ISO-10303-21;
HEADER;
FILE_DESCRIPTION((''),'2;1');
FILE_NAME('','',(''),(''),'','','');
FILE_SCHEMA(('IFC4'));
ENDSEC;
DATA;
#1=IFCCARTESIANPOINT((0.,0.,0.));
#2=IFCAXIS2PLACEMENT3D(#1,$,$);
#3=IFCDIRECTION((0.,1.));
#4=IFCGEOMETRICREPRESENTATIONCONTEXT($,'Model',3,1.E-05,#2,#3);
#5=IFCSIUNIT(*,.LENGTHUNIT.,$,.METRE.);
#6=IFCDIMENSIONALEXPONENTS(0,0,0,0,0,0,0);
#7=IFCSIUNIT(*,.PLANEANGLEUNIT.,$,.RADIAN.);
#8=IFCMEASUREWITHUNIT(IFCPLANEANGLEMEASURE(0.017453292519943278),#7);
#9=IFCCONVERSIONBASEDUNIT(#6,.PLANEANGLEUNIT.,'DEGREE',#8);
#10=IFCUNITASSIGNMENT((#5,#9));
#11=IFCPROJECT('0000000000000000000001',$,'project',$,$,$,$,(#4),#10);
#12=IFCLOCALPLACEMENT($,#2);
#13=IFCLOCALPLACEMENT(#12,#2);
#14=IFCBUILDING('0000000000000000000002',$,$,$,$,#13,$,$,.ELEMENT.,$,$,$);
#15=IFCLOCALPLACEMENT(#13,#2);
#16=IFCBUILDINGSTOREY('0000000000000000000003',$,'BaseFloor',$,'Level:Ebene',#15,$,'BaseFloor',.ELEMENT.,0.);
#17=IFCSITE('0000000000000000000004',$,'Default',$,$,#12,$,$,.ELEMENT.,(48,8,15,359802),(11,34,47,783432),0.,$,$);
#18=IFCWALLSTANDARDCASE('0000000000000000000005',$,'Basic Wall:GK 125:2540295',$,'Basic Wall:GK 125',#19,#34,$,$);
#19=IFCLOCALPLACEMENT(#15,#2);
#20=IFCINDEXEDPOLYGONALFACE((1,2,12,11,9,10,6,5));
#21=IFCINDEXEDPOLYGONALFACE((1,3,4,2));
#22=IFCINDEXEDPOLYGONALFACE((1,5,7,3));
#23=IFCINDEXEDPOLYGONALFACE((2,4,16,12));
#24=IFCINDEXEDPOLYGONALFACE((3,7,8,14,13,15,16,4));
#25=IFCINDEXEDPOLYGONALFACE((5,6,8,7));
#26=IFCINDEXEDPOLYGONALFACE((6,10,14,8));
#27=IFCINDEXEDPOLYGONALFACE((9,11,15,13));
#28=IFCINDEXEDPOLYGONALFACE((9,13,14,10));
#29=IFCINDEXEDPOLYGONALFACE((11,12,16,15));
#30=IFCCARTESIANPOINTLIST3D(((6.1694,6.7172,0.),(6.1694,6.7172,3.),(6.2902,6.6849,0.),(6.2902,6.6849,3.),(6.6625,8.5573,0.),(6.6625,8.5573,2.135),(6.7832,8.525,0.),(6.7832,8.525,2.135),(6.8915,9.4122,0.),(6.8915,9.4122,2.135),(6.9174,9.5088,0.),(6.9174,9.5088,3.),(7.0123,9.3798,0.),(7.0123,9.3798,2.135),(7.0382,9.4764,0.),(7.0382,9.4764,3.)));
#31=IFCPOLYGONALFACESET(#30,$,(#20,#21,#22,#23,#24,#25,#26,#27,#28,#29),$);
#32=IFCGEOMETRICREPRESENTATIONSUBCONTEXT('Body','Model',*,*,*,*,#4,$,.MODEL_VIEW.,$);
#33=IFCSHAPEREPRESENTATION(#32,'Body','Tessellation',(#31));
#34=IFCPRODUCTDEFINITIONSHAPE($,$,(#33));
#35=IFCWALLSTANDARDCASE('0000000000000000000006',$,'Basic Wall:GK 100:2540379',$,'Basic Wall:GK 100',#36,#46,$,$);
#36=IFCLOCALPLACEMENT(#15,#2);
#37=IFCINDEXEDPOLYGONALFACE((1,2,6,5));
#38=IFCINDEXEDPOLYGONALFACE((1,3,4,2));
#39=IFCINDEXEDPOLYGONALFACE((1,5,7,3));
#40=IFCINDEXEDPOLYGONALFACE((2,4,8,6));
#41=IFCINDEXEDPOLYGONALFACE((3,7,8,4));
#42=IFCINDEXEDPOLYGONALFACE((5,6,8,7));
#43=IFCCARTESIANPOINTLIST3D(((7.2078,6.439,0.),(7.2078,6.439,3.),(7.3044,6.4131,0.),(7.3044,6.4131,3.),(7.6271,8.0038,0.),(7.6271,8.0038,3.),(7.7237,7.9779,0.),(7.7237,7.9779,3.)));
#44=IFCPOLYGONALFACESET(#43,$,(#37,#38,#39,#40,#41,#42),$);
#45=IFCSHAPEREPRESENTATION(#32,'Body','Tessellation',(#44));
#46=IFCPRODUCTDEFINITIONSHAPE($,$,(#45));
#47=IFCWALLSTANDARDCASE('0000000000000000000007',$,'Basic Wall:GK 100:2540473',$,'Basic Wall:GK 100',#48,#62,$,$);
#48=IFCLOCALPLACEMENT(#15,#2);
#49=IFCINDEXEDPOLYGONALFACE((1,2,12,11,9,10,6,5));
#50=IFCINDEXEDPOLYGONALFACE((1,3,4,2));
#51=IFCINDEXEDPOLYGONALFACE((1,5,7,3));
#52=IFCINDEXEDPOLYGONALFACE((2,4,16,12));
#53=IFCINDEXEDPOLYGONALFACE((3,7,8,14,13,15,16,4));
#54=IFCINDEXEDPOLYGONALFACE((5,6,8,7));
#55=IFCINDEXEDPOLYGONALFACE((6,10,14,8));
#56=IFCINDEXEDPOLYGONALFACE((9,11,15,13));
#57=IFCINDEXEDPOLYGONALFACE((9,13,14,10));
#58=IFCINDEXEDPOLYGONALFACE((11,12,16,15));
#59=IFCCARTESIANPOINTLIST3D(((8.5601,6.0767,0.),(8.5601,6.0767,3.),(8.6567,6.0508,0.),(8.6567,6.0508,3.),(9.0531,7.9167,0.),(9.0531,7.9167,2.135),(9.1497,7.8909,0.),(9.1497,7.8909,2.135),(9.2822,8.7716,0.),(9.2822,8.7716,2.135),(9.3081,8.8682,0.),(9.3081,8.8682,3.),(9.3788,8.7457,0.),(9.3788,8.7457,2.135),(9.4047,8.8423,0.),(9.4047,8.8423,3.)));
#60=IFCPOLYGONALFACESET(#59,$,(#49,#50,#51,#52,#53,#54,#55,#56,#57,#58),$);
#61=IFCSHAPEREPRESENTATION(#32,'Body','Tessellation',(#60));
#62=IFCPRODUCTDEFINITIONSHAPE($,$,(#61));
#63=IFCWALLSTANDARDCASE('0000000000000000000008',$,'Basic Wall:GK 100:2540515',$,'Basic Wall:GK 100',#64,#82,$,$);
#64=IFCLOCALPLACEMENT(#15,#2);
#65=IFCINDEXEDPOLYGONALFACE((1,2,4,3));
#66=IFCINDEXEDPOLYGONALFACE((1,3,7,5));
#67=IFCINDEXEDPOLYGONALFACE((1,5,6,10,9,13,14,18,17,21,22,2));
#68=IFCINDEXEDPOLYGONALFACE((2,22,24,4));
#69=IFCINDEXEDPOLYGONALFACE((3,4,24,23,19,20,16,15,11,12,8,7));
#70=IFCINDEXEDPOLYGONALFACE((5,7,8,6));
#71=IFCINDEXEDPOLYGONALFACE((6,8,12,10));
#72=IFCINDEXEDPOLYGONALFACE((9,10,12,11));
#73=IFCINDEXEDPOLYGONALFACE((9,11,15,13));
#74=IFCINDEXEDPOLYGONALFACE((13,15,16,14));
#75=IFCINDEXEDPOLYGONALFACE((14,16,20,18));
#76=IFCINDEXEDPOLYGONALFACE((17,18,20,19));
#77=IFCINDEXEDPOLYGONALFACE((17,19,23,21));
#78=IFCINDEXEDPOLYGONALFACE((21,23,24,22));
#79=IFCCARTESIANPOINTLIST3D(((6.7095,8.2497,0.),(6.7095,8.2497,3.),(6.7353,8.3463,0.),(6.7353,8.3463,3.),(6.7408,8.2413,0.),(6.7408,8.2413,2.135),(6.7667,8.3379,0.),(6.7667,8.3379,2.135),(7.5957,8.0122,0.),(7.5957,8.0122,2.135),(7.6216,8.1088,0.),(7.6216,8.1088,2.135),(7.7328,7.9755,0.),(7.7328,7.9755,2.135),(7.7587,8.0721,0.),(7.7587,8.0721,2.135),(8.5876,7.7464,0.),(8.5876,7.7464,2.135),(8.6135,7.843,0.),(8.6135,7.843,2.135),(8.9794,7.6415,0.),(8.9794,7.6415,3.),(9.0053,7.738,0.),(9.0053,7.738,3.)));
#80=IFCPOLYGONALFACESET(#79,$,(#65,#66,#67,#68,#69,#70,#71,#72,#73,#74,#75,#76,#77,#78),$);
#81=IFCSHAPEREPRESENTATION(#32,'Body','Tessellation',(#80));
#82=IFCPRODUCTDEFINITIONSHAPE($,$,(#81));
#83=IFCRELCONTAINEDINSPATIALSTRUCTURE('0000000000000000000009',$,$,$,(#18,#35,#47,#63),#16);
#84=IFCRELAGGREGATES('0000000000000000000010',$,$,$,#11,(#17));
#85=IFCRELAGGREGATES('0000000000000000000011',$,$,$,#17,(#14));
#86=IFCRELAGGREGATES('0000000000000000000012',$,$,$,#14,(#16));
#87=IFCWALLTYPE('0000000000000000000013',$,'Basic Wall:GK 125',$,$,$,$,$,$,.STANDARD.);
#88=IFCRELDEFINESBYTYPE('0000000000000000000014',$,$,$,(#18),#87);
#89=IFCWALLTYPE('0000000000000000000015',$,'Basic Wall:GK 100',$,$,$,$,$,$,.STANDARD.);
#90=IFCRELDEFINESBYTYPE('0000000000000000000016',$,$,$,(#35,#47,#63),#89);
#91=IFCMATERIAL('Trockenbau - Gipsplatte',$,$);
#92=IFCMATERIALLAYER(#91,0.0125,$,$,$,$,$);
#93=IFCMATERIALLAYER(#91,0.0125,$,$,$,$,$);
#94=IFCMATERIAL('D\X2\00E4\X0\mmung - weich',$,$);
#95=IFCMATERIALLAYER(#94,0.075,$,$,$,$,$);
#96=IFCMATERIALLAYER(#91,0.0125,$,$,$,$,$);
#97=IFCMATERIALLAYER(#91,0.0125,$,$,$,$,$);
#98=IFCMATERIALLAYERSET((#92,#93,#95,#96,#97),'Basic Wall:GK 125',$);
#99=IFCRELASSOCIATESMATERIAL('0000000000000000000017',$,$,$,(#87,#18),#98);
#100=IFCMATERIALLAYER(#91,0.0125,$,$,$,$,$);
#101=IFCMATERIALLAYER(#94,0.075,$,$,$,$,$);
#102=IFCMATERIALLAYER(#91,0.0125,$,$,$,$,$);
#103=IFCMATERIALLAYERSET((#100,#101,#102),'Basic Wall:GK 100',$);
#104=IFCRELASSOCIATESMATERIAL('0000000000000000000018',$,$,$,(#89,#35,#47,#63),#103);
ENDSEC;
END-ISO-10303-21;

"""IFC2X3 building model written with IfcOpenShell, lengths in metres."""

from ifc_helpers import new_model, entity, si_unit, converted_unit, direction, frame, frame_2d, origin, place, context, subcontext, project, spatial, rectangle, extrude, material, layer, layer_set, layer_usage, type_object, element, save


model = new_model("IFC2X3")

# Units and contexts
model_context = context("Model", 3, precision=1e-05, world=origin(), true_north=direction((0.0, 1.0)))
body_context = subcontext(model_context, "Body", "Model", "MODEL_VIEW")
ifc_project = project(units=[si_unit("LENGTHUNIT", "METRE"), converted_unit("PLANEANGLEUNIT", "DEGREE", entity("IfcPlaneAngleMeasure", 0.017453292519943278), si_unit("PLANEANGLEUNIT", "RADIAN"), dimensions=[0, 0, 0, 0, 0, 0, 0])], contexts=[model_context])

# Site, building, storey
site_placement = place(None, origin())
site = spatial("IfcSite", under=ifc_project, at=site_placement, Name="Default", CompositionType="ELEMENT", RefLatitude=(48, 8, 15, 359802), RefLongitude=(11, 34, 47, 783432), RefElevation=0.0)
building_placement = place(site_placement, origin())
building = spatial("IfcBuilding", under=site, at=building_placement, CompositionType="ELEMENT")
storey_placement = place(building_placement, origin())
storey = spatial("IfcBuildingStorey", under=building, at=storey_placement, Name="BaseFloor", ObjectType="Level:Ebene", LongName="BaseFloor", CompositionType="ELEMENT", Elevation=0.0)

# Wall, opening
ifc_material_1 = material(Name="Trockenbau - Gipsplatte")
ifc_layer_1 = layer(ifc_material_1, 0.0125)
ifc_layer_2 = layer(ifc_material_1, 0.0125)
ifc_material_2 = material(Name="Dämmung - weich")
ifc_layer_3 = layer(ifc_material_2, 0.075)
ifc_layer_4 = layer(ifc_material_1, 0.0125)
ifc_layer_5 = layer(ifc_material_1, 0.0125)
ifc_layer_set_1 = layer_set([ifc_layer_1, ifc_layer_2, ifc_layer_3, ifc_layer_4, ifc_layer_5], Name="Basic Wall:GK 125")
ifc_layer_usage_1 = layer_usage(ifc_layer_set_1, "AXIS2", "NEGATIVE", 0.0625)
wall_type_1 = type_object("IfcWallType", Name="Basic Wall:GK 125", PredefinedType="STANDARD", material=ifc_layer_set_1)
wall_1_placement = place(storey_placement, frame((6.2298, 6.7011, 0.0), z_axis=(0.0, 0.0, 1.0), x_axis=(0.258819, 0.965926, 0.0)))
wall_1 = element("IfcWallStandardCase", 1, at=wall_1_placement, inside=storey, type_object=wall_type_1, material=ifc_layer_usage_1, Name="Basic Wall:GK 125:2540295", ObjectType="Basic Wall:GK 125", context=body_context, shape_type="SweptSolid", body=[
    extrude(rectangle(XDim=2.89, YDim=0.125, at=frame_2d((1.445, 0.0), x_axis=(-1.0, 0.0))), origin(), (0.0, 0.0, 1.0), 3.0),
])
opening_1_placement = place(wall_1_placement, frame((1.905, -0.0625, -0.18)))
element("IfcOpeningElement", 2, at=opening_1_placement, cuts=wall_1, ObjectType="Opening", context=body_context, shape_type="SweptSolid", body=[
    extrude(rectangle(XDim=2.315, YDim=0.885, at=frame_2d((1.1575, 0.4425), x_axis=(-1.0, 0.0))), frame((0.0, 0.0, 0.0), z_axis=(0.0, 1.0, 0.0), x_axis=(0.0, 0.0, 1.0)), (0.0, 0.0, 1.0), 0.125),
])

# Wall
ifc_layer_6 = layer(ifc_material_1, 0.0125)
ifc_layer_7 = layer(ifc_material_2, 0.075)
ifc_layer_8 = layer(ifc_material_1, 0.0125)
ifc_layer_set_2 = layer_set([ifc_layer_6, ifc_layer_7, ifc_layer_8], Name="Basic Wall:GK 100")
ifc_layer_usage_2 = layer_usage(ifc_layer_set_2, "AXIS2", "NEGATIVE", 0.05)
wall_type_2 = type_object("IfcWallType", Name="Basic Wall:GK 100", PredefinedType="STANDARD", material=ifc_layer_set_2)
wall_2_placement = place(storey_placement, frame((7.2561, 6.4261, 0.0), z_axis=(0.0, 0.0, 1.0), x_axis=(0.258819, 0.965926, 0.0)))
element("IfcWallStandardCase", 3, at=wall_2_placement, inside=storey, type_object=wall_type_2, material=ifc_layer_usage_2, Name="Basic Wall:GK 100:2540379", ObjectType="Basic Wall:GK 100", context=body_context, shape_type="SweptSolid", body=[
    extrude(rectangle(XDim=1.62, YDim=0.1, at=frame_2d((0.81, 0.0), x_axis=(-1.0, 0.0))), origin(), (0.0, 0.0, 1.0), 3.0),
])

# Wall, opening
ifc_layer_usage_3 = layer_usage(ifc_layer_set_2, "AXIS2", "NEGATIVE", 0.05)
wall_3_placement = place(storey_placement, frame((8.6084, 6.0637, 0.0), z_axis=(0.0, 0.0, 1.0), x_axis=(0.258819, 0.965926, 0.0)))
wall_3 = element("IfcWallStandardCase", 4, at=wall_3_placement, inside=storey, type_object=wall_type_2, material=ifc_layer_usage_3, Name="Basic Wall:GK 100:2540473", ObjectType="Basic Wall:GK 100", context=body_context, shape_type="SweptSolid", body=[
    extrude(rectangle(XDim=2.89, YDim=0.1, at=frame_2d((1.445, 0.0), x_axis=(-1.0, 0.0))), origin(), (0.0, 0.0, 1.0), 3.0),
])
opening_2_placement = place(wall_3_placement, frame((2.79, 0.05, -0.18)))
element("IfcOpeningElement", 5, at=opening_2_placement, cuts=wall_3, ObjectType="Opening", context=body_context, shape_type="SweptSolid", body=[
    extrude(rectangle(XDim=2.315, YDim=0.885, at=frame_2d((1.1575, 0.4425), x_axis=(-1.0, 0.0))), frame((0.0, 0.0, 0.0), z_axis=(0.0, -1.0, 0.0), x_axis=(0.0, 0.0, 1.0)), (0.0, 0.0, 1.0), 0.1),
])

# Wall, openings
ifc_layer_usage_4 = layer_usage(ifc_layer_set_2, "AXIS2", "NEGATIVE", 0.05)
wall_4_placement = place(storey_placement, frame((8.9923, 7.6898, 0.0), z_axis=(0.0, 0.0, 1.0), x_axis=(-0.965926, 0.258819, 0.0)))
wall_4 = element("IfcWallStandardCase", 6, at=wall_4_placement, inside=storey, type_object=wall_type_2, material=ifc_layer_usage_4, Name="Basic Wall:GK 100:2540515", ObjectType="Basic Wall:GK 100", context=body_context, shape_type="SweptSolid", body=[
    extrude(rectangle(XDim=2.35, YDim=0.1, at=frame_2d((1.175, 0.0), x_axis=(1.0, 0.0))), origin(), (0.0, 0.0, 1.0), 3.0),
])
opening_3_placement = place(wall_4_placement, frame((1.4325, -0.05, -0.18)))
element("IfcOpeningElement", 7, at=opening_3_placement, cuts=wall_4, ObjectType="Opening", context=body_context, shape_type="SweptSolid", body=[
    extrude(rectangle(XDim=2.315, YDim=0.885, at=frame_2d((1.1575, 0.4425), x_axis=(-1.0, 0.0))), frame((0.0, 0.0, 0.0), z_axis=(0.0, 1.0, 0.0), x_axis=(0.0, 0.0, 1.0)), (0.0, 0.0, 1.0), 0.1),
])
opening_4_placement = place(wall_4_placement, frame((0.4056, -0.05, -0.18)))
element("IfcOpeningElement", 8, at=opening_4_placement, cuts=wall_4, ObjectType="Opening", context=body_context, shape_type="SweptSolid", body=[
    extrude(rectangle(XDim=2.315, YDim=0.885, at=frame_2d((1.1575, 0.4425), x_axis=(-1.0, 0.0))), frame((0.0, 0.0, 0.0), z_axis=(0.0, 1.0, 0.0), x_axis=(0.0, 0.0, 1.0)), (0.0, 0.0, 1.0), 0.1),
])

save(model, "model.ifc")
